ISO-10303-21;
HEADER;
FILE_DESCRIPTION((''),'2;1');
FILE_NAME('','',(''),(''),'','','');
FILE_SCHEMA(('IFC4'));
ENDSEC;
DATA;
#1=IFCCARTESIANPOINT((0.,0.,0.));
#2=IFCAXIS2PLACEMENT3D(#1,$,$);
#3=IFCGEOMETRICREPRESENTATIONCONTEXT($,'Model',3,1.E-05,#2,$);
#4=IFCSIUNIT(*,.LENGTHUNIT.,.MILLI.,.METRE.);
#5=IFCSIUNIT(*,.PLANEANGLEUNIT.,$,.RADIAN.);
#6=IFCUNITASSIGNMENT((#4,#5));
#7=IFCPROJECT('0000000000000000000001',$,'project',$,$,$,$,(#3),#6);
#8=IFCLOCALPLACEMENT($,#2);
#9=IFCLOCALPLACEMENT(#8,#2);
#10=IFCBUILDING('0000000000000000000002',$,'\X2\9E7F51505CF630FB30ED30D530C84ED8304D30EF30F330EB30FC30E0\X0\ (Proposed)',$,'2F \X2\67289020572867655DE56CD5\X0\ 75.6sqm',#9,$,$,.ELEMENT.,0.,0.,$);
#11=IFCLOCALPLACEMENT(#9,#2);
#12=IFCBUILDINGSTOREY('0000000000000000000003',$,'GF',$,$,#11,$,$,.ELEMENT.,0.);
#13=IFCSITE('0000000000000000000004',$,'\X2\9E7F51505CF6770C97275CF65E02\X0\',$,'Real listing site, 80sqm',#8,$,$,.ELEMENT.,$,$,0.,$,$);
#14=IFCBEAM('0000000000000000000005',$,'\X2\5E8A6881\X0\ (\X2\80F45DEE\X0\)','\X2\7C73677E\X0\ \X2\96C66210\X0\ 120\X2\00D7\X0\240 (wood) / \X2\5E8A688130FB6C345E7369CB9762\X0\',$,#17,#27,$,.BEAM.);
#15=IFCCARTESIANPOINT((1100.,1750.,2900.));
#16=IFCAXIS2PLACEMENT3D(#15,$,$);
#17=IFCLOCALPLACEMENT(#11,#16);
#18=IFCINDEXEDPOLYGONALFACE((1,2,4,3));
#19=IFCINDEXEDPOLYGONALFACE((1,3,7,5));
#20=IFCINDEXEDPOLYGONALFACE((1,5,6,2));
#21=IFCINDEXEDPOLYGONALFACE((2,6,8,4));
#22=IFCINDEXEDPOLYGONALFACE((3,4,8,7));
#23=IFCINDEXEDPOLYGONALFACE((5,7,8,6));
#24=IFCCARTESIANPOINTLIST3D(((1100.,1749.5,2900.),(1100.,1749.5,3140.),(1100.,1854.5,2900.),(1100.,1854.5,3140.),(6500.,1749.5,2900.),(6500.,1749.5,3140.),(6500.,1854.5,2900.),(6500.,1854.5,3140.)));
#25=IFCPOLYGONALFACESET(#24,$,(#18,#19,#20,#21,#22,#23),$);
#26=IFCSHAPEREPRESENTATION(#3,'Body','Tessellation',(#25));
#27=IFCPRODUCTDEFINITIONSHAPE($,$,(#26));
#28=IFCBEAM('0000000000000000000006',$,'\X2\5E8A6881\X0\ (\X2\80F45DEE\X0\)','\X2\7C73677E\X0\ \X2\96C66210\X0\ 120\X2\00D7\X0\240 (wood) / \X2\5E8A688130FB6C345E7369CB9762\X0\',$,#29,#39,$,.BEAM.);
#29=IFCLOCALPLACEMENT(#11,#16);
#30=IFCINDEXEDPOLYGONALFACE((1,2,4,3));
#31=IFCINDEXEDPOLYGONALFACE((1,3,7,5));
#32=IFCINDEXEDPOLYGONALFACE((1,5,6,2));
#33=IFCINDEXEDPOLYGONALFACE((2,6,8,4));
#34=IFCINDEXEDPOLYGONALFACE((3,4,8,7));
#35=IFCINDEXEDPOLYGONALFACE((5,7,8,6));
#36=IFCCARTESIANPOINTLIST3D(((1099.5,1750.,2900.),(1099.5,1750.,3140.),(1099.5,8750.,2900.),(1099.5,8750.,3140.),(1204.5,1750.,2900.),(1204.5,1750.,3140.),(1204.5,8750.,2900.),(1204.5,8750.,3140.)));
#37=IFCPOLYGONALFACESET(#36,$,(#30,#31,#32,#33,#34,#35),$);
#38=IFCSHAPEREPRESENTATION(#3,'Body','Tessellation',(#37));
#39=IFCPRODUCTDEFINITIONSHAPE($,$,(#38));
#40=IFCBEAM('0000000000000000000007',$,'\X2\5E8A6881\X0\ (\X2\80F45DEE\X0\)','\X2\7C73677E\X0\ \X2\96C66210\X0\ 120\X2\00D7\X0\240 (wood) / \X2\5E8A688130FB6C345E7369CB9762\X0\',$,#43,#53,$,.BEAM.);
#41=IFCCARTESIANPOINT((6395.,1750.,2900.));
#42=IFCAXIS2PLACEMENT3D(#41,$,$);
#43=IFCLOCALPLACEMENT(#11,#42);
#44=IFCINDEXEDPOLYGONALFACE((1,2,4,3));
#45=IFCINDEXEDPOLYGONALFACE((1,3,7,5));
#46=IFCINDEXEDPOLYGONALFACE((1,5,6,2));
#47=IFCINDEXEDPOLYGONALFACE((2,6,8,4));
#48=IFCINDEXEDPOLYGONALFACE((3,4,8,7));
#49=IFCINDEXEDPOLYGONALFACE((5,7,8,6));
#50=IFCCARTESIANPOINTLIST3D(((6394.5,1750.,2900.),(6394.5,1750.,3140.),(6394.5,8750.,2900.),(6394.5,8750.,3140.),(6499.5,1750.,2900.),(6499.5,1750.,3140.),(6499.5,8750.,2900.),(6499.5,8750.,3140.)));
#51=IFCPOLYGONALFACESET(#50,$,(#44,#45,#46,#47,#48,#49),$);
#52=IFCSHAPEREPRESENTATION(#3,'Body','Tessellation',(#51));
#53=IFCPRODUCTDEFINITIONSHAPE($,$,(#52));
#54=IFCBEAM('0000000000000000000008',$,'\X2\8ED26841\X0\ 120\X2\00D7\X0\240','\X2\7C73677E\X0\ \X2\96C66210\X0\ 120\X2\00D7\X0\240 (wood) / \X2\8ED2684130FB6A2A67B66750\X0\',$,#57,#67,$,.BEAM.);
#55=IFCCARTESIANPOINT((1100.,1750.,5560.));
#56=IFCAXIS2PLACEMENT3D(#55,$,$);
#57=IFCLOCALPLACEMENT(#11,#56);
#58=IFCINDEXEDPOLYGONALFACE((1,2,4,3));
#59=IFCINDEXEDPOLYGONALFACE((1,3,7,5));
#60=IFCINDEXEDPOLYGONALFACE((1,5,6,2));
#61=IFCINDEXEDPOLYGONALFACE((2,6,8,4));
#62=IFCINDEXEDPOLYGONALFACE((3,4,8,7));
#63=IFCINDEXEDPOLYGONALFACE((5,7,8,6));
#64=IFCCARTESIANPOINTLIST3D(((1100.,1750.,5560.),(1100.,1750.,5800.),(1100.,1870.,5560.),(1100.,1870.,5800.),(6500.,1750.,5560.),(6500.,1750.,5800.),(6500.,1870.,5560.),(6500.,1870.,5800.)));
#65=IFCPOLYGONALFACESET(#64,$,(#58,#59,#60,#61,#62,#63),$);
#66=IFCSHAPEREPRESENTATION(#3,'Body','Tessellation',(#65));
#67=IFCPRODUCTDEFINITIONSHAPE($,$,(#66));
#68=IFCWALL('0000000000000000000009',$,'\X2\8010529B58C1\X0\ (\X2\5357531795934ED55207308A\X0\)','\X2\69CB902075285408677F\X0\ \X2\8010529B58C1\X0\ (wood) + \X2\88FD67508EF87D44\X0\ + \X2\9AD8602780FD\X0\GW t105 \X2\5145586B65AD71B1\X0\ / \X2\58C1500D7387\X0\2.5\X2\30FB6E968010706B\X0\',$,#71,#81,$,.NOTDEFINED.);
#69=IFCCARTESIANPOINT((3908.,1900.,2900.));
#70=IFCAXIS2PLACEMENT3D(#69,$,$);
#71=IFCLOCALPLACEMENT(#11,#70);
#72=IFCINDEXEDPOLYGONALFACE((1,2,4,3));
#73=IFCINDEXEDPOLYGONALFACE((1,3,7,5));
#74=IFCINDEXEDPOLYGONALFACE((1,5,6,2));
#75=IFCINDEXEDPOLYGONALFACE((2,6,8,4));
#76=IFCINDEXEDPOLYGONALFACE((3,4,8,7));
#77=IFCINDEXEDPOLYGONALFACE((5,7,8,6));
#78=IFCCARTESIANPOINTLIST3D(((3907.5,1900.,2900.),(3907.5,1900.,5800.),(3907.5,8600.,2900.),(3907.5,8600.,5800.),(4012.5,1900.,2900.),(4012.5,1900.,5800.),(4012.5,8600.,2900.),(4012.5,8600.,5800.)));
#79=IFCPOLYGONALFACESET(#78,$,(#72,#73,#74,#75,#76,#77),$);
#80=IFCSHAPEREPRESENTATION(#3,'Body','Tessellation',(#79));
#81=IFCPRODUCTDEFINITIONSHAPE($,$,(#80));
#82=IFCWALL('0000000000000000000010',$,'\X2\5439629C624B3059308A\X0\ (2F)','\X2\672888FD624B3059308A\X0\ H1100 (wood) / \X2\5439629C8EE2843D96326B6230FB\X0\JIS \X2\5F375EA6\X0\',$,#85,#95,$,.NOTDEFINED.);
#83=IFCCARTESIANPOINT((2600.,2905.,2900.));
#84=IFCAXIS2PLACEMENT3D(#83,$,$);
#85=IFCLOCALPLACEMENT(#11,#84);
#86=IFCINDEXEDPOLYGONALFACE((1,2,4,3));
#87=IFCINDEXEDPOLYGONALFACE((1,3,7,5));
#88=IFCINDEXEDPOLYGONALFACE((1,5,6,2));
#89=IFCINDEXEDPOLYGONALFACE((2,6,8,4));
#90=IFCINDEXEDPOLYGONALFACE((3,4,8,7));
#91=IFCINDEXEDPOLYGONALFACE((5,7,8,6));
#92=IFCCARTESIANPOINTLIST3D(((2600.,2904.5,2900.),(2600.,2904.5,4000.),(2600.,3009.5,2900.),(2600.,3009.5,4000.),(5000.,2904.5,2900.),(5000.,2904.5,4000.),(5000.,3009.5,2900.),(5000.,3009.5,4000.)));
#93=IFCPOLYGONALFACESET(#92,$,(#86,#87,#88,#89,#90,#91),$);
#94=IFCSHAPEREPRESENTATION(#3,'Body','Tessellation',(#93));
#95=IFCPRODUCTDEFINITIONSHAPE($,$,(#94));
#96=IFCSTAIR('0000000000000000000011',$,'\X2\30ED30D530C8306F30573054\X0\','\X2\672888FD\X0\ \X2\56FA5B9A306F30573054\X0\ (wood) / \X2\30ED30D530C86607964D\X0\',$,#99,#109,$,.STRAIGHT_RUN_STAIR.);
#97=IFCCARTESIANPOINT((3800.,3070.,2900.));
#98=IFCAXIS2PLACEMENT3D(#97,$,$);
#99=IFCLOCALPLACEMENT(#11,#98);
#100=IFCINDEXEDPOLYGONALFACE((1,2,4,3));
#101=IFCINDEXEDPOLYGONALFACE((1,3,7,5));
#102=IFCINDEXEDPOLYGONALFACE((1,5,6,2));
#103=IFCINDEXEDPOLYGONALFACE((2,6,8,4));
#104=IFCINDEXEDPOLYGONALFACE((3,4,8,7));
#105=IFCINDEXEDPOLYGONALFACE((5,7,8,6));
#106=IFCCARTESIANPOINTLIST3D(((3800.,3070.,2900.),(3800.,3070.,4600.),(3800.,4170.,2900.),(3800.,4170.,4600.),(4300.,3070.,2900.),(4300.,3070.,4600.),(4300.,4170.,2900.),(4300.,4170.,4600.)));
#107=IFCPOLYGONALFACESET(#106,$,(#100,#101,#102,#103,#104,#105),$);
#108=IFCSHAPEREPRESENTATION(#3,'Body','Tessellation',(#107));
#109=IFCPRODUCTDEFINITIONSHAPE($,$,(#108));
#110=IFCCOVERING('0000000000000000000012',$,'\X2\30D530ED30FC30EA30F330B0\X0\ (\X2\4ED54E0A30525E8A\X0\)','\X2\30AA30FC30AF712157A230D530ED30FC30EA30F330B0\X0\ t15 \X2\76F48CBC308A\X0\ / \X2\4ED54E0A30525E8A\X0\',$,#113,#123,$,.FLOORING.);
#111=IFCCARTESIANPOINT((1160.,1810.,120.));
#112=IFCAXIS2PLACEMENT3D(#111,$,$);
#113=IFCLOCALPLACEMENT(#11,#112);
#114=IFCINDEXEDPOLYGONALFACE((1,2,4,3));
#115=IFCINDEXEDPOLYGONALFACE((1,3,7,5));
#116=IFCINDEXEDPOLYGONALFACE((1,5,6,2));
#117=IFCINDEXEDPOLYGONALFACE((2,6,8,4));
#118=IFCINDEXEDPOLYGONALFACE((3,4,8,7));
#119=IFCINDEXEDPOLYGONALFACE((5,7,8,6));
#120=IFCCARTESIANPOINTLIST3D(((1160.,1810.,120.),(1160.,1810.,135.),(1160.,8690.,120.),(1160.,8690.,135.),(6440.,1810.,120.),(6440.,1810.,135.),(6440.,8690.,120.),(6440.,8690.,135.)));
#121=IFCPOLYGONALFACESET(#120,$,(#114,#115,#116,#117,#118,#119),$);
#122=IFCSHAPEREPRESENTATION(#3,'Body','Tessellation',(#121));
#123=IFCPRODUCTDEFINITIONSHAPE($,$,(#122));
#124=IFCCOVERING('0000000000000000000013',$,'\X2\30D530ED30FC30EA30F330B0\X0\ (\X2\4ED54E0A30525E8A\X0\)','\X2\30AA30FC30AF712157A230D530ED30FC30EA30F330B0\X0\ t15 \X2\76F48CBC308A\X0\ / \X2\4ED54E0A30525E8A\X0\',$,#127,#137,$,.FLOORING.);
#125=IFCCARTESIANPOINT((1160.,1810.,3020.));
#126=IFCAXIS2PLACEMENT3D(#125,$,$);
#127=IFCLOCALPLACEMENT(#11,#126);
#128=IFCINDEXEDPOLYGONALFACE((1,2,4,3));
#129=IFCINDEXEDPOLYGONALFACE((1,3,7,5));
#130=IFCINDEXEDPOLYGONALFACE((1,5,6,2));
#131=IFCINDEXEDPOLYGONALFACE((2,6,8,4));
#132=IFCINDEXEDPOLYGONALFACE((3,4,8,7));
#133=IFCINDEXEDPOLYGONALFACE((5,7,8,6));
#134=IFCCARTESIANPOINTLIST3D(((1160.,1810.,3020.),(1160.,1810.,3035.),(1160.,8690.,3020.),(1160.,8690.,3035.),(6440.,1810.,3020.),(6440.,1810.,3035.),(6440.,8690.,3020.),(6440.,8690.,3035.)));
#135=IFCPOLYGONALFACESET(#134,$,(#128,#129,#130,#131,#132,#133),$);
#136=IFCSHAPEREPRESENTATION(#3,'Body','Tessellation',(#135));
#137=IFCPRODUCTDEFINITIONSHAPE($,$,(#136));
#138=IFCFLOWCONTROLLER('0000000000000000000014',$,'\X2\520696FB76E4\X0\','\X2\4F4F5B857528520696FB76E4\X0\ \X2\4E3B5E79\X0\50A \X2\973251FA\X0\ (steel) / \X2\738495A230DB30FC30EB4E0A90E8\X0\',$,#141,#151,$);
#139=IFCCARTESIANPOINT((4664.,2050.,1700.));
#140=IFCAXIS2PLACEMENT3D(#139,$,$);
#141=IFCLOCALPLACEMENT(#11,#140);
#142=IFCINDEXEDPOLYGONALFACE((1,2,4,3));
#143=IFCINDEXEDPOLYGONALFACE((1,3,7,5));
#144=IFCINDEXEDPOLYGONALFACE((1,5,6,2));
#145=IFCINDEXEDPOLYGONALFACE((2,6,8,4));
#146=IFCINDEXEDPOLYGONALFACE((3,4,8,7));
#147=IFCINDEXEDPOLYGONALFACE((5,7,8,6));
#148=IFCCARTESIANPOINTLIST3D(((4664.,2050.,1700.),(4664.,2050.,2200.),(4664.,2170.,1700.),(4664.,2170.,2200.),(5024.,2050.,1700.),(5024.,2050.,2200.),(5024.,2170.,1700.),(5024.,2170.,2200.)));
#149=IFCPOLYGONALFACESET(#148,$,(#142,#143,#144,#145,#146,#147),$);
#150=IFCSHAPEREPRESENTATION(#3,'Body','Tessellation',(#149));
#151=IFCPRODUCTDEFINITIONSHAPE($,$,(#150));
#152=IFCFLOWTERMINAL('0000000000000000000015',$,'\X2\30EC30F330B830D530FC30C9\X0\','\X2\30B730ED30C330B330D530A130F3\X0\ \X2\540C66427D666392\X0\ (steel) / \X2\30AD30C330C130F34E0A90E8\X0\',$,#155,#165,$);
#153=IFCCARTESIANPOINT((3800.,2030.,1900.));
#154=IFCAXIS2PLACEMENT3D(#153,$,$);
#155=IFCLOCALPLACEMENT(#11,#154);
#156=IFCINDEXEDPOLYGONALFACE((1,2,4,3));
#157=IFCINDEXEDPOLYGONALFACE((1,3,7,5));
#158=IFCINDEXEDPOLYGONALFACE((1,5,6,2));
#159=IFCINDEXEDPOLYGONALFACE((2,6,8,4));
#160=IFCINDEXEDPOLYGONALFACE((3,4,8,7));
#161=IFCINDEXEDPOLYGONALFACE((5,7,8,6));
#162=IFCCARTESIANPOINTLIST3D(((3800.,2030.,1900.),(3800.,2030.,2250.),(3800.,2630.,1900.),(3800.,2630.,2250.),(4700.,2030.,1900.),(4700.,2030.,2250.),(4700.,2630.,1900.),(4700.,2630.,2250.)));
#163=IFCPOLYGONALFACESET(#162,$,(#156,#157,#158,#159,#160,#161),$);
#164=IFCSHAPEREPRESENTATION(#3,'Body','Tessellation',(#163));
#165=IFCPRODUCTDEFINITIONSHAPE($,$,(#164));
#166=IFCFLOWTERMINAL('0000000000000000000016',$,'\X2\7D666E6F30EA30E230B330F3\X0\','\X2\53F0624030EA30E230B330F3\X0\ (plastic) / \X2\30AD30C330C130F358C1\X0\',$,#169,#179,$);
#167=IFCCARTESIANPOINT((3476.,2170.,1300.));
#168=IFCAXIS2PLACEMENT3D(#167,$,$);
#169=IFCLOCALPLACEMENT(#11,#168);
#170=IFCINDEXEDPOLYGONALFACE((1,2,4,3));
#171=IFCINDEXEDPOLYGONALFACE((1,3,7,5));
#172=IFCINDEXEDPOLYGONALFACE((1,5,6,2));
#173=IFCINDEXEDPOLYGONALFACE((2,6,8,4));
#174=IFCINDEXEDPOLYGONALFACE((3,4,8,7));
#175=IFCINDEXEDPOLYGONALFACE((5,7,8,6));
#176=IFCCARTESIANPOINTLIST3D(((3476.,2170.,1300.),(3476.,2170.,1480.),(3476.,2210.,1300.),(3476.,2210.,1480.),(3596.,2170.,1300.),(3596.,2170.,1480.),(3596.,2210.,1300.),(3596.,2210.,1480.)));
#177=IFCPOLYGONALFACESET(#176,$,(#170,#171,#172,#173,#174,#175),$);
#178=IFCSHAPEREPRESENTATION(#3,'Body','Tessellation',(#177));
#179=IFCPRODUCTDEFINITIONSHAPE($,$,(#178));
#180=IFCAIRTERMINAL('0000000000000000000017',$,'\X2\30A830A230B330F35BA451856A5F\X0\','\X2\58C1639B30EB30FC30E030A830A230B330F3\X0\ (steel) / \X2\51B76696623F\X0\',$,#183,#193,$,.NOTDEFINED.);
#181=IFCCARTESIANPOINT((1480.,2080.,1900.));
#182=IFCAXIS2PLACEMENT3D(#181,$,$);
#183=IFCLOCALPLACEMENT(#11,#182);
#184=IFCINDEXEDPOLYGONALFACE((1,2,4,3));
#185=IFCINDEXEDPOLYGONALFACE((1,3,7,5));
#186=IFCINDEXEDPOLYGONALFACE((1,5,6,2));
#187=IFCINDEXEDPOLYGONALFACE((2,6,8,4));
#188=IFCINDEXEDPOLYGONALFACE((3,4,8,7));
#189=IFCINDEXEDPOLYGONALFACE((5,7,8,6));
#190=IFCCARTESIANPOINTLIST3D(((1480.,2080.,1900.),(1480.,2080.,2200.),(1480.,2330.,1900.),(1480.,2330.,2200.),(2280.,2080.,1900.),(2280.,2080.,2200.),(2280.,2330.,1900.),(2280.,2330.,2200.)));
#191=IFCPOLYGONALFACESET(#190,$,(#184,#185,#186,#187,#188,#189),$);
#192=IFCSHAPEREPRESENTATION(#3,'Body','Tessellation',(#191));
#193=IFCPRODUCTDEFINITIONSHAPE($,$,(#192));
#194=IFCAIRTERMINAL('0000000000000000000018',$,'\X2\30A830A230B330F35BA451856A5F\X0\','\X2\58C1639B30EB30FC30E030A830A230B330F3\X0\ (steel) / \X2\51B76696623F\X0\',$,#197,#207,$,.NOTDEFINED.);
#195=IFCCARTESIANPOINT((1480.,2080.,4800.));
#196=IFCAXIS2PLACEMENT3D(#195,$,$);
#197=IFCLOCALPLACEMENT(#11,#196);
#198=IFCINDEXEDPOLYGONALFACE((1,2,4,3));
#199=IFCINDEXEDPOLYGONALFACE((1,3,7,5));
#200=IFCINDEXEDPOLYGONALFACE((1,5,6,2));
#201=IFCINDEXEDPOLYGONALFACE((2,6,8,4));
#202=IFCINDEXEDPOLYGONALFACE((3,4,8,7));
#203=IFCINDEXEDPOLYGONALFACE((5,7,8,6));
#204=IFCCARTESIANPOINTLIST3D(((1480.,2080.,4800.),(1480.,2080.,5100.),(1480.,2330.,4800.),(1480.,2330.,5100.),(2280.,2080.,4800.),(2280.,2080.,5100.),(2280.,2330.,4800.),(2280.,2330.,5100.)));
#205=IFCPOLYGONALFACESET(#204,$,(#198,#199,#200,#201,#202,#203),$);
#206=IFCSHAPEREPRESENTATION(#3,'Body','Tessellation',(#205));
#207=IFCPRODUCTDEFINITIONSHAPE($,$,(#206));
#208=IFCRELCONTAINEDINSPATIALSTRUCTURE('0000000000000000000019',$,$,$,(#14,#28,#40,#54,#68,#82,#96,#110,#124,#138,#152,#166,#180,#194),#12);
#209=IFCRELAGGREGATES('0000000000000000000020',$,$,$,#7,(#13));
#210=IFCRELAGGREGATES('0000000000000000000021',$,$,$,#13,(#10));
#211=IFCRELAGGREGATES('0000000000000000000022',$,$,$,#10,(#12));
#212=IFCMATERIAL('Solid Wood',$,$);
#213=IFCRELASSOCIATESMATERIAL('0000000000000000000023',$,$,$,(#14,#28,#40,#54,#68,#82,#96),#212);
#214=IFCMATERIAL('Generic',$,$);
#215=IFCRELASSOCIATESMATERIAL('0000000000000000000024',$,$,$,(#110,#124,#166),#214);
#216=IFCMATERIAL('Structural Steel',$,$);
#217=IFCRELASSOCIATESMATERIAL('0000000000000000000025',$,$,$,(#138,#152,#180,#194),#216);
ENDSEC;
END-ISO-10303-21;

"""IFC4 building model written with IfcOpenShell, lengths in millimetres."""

from ifc_helpers import new_model, si_unit, frame, frame_2d, origin, place, context, project, spatial, rectangle, extrude, material, element, save


model = new_model("IFC4")

# Units and contexts
model_context = context("Model", 3, precision=1e-05, world=origin())
ifc_project = project(units=[si_unit("LENGTHUNIT", "METRE", prefix="MILLI"), si_unit("PLANEANGLEUNIT", "RADIAN")], contexts=[model_context])

# Site, building, storey
site_placement = place(None, origin())
site = spatial("IfcSite", under=ifc_project, at=site_placement, Name="鹿児島県霧島市", ObjectType="Real listing site, 80sqm", CompositionType="ELEMENT", RefElevation=0.0)
building_placement = place(site_placement, origin())
building = spatial("IfcBuilding", under=site, at=building_placement, Name="鹿児島・ロフト付きワンルーム (Proposed)", ObjectType="2F 木造在来工法 75.6sqm", CompositionType="ELEMENT", ElevationOfRefHeight=0.0, ElevationOfTerrain=0.0)
storey_placement = place(building_placement, origin())
storey = spatial("IfcBuildingStorey", under=building, at=storey_placement, Name="GF", CompositionType="ELEMENT", Elevation=0.0)

# Shared definitions
ifc_material_1 = material(Name="Solid Wood")

# Beams
beam_1_placement = place(storey_placement, frame((1100.0, 1750.0, 2900.0)))
element("IfcBeam", 1, at=beam_1_placement, inside=storey, material=ifc_material_1, Name="床梁 (胴差)", Description="米松 集成 120×240 (wood) / 床梁・水平構面", PredefinedType="BEAM", context=model_context, shape_type="SweptSolid", body=[
    extrude(rectangle(XDim=5400.0, YDim=105.0, at=frame_2d((2700.0, 52.0))), frame((1100.0, 1750.0, 2900.0)), (0.0, 0.0, 1.0), 240.0),
])
beam_2_placement = place(storey_placement, frame((1100.0, 1750.0, 2900.0)))
element("IfcBeam", 2, at=beam_2_placement, inside=storey, material=ifc_material_1, Name="床梁 (胴差)", Description="米松 集成 120×240 (wood) / 床梁・水平構面", PredefinedType="BEAM", context=model_context, shape_type="SweptSolid", body=[
    extrude(rectangle(XDim=105.0, YDim=7000.0, at=frame_2d((52.0, 3500.0))), frame((1100.0, 1750.0, 2900.0)), (0.0, 0.0, 1.0), 240.0),
])
beam_3_placement = place(storey_placement, frame((6395.0, 1750.0, 2900.0)))
element("IfcBeam", 3, at=beam_3_placement, inside=storey, material=ifc_material_1, Name="床梁 (胴差)", Description="米松 集成 120×240 (wood) / 床梁・水平構面", PredefinedType="BEAM", context=model_context, shape_type="SweptSolid", body=[
    extrude(rectangle(XDim=105.0, YDim=7000.0, at=frame_2d((52.0, 3500.0))), frame((6395.0, 1750.0, 2900.0)), (0.0, 0.0, 1.0), 240.0),
])
beam_4_placement = place(storey_placement, frame((1100.0, 1750.0, 5560.0)))
element("IfcBeam", 4, at=beam_4_placement, inside=storey, material=ifc_material_1, Name="軒桁 120×240", Description="米松 集成 120×240 (wood) / 軒桁・横架材", PredefinedType="BEAM", context=model_context, shape_type="SweptSolid", body=[
    extrude(rectangle(XDim=5400.0, YDim=120.0, at=frame_2d((2700.0, 60.0))), frame((1100.0, 1750.0, 5560.0)), (0.0, 0.0, 1.0), 240.0),
])

# Walls
wall_1_placement = place(storey_placement, frame((3908.0, 1900.0, 2900.0)))
element("IfcWall", 5, at=wall_1_placement, inside=storey, material=ifc_material_1, Name="耐力壁 (南北間仕切り)", Description="構造用合板 耐力壁 (wood) + 製材軸組 + 高性能GW t105 充填断熱 / 壁倍率2.5・準耐火", PredefinedType="NOTDEFINED", context=model_context, shape_type="SweptSolid", body=[
    extrude(rectangle(XDim=105.0, YDim=6700.0, at=frame_2d((52.0, 3350.0))), frame((3908.0, 1900.0, 2900.0)), (0.0, 0.0, 1.0), 2900.0),
])
wall_2_placement = place(storey_placement, frame((2600.0, 2905.0, 2900.0)))
element("IfcWall", 6, at=wall_2_placement, inside=storey, material=ifc_material_1, Name="吹抜手すり (2F)", Description="木製手すり H1100 (wood) / 吹抜転落防止・JIS 強度", PredefinedType="NOTDEFINED", context=model_context, shape_type="SweptSolid", body=[
    extrude(rectangle(XDim=2400.0, YDim=105.0, at=frame_2d((1200.0, 52.0))), frame((2600.0, 2905.0, 2900.0)), (0.0, 0.0, 1.0), 1100.0),
])

# Stair
stair_1_placement = place(storey_placement, frame((3800.0, 3070.0, 2900.0)))
element("IfcStair", 7, at=stair_1_placement, inside=storey, material=ifc_material_1, Name="ロフトはしご", Description="木製 固定はしご (wood) / ロフト昇降", PredefinedType="STRAIGHT_RUN_STAIR", context=model_context, shape_type="SweptSolid", body=[
    extrude(rectangle(XDim=500.0, YDim=1100.0, at=frame_2d((250.0, 550.0))), frame((3800.0, 3070.0, 2900.0)), (0.0, 0.0, 1.0), 1700.0),
])

# Coverings
ifc_material_2 = material(Name="Generic")
covering_1_placement = place(storey_placement, frame((1160.0, 1810.0, 120.0)))
element("IfcCovering", 8, at=covering_1_placement, inside=storey, material=ifc_material_2, Name="フローリング (仕上げ床)", Description="オーク無垢フローリング t15 直貼り / 仕上げ床", PredefinedType="FLOORING", context=model_context, shape_type="SweptSolid", body=[
    extrude(rectangle(XDim=5280.0, YDim=6880.0, at=frame_2d((2640.0, 3440.0))), frame((1160.0, 1810.0, 120.0)), (0.0, 0.0, 1.0), 15.0),
])
covering_2_placement = place(storey_placement, frame((1160.0, 1810.0, 3020.0)))
element("IfcCovering", 9, at=covering_2_placement, inside=storey, material=ifc_material_2, Name="フローリング (仕上げ床)", Description="オーク無垢フローリング t15 直貼り / 仕上げ床", PredefinedType="FLOORING", context=model_context, shape_type="SweptSolid", body=[
    extrude(rectangle(XDim=5280.0, YDim=6880.0, at=frame_2d((2640.0, 3440.0))), frame((1160.0, 1810.0, 3020.0)), (0.0, 0.0, 1.0), 15.0),
])

# Flow controller
ifc_material_3 = material(Name="Structural Steel")
flow_controller_placement = place(storey_placement, frame((4664.0, 2050.0, 1700.0)))
element("IfcFlowController", 10, at=flow_controller_placement, inside=storey, material=ifc_material_3, Name="分電盤", Description="住宅用分電盤 主幹50A 露出 (steel) / 玄関ホール上部", context=model_context, shape_type="SweptSolid", body=[
    extrude(rectangle(XDim=360.0, YDim=120.0, at=frame_2d((180.0, 60.0))), frame((4664.0, 2050.0, 1700.0)), (0.0, 0.0, 1.0), 500.0),
])

# Flow terminals
flow_terminal_1_placement = place(storey_placement, frame((3800.0, 2030.0, 1900.0)))
element("IfcFlowTerminal", 11, at=flow_terminal_1_placement, inside=storey, material=ifc_material_3, Name="レンジフード", Description="シロッコファン 同時給排 (steel) / キッチン上部", context=model_context, shape_type="SweptSolid", body=[
    extrude(rectangle(XDim=900.0, YDim=600.0, at=frame_2d((450.0, 300.0))), frame((3800.0, 2030.0, 1900.0)), (0.0, 0.0, 1.0), 350.0),
])
flow_terminal_2_placement = place(storey_placement, frame((3476.0, 2170.0, 1300.0)))
element("IfcFlowTerminal", 12, at=flow_terminal_2_placement, inside=storey, material=ifc_material_2, Name="給湯リモコン", Description="台所リモコン (plastic) / キッチン壁", context=model_context, shape_type="SweptSolid", body=[
    extrude(rectangle(XDim=120.0, YDim=40.0, at=frame_2d((60.0, 20.0))), frame((3476.0, 2170.0, 1300.0)), (0.0, 0.0, 1.0), 180.0),
])

# Air terminals
air_terminal_1_placement = place(storey_placement, frame((1480.0, 2080.0, 1900.0)))
element("IfcAirTerminal", 13, at=air_terminal_1_placement, inside=storey, material=ifc_material_3, Name="エアコン室内機", Description="壁掛ルームエアコン (steel) / 冷暖房", PredefinedType="NOTDEFINED", context=model_context, shape_type="SweptSolid", body=[
    extrude(rectangle(XDim=800.0, YDim=250.0, at=frame_2d((400.0, 125.0))), frame((1480.0, 2080.0, 1900.0)), (0.0, 0.0, 1.0), 300.0),
])
air_terminal_2_placement = place(storey_placement, frame((1480.0, 2080.0, 4800.0)))
element("IfcAirTerminal", 14, at=air_terminal_2_placement, inside=storey, material=ifc_material_3, Name="エアコン室内機", Description="壁掛ルームエアコン (steel) / 冷暖房", PredefinedType="NOTDEFINED", context=model_context, shape_type="SweptSolid", body=[
    extrude(rectangle(XDim=800.0, YDim=250.0, at=frame_2d((400.0, 125.0))), frame((1480.0, 2080.0, 4800.0)), (0.0, 0.0, 1.0), 300.0),
])

save(model, "model.ifc")
